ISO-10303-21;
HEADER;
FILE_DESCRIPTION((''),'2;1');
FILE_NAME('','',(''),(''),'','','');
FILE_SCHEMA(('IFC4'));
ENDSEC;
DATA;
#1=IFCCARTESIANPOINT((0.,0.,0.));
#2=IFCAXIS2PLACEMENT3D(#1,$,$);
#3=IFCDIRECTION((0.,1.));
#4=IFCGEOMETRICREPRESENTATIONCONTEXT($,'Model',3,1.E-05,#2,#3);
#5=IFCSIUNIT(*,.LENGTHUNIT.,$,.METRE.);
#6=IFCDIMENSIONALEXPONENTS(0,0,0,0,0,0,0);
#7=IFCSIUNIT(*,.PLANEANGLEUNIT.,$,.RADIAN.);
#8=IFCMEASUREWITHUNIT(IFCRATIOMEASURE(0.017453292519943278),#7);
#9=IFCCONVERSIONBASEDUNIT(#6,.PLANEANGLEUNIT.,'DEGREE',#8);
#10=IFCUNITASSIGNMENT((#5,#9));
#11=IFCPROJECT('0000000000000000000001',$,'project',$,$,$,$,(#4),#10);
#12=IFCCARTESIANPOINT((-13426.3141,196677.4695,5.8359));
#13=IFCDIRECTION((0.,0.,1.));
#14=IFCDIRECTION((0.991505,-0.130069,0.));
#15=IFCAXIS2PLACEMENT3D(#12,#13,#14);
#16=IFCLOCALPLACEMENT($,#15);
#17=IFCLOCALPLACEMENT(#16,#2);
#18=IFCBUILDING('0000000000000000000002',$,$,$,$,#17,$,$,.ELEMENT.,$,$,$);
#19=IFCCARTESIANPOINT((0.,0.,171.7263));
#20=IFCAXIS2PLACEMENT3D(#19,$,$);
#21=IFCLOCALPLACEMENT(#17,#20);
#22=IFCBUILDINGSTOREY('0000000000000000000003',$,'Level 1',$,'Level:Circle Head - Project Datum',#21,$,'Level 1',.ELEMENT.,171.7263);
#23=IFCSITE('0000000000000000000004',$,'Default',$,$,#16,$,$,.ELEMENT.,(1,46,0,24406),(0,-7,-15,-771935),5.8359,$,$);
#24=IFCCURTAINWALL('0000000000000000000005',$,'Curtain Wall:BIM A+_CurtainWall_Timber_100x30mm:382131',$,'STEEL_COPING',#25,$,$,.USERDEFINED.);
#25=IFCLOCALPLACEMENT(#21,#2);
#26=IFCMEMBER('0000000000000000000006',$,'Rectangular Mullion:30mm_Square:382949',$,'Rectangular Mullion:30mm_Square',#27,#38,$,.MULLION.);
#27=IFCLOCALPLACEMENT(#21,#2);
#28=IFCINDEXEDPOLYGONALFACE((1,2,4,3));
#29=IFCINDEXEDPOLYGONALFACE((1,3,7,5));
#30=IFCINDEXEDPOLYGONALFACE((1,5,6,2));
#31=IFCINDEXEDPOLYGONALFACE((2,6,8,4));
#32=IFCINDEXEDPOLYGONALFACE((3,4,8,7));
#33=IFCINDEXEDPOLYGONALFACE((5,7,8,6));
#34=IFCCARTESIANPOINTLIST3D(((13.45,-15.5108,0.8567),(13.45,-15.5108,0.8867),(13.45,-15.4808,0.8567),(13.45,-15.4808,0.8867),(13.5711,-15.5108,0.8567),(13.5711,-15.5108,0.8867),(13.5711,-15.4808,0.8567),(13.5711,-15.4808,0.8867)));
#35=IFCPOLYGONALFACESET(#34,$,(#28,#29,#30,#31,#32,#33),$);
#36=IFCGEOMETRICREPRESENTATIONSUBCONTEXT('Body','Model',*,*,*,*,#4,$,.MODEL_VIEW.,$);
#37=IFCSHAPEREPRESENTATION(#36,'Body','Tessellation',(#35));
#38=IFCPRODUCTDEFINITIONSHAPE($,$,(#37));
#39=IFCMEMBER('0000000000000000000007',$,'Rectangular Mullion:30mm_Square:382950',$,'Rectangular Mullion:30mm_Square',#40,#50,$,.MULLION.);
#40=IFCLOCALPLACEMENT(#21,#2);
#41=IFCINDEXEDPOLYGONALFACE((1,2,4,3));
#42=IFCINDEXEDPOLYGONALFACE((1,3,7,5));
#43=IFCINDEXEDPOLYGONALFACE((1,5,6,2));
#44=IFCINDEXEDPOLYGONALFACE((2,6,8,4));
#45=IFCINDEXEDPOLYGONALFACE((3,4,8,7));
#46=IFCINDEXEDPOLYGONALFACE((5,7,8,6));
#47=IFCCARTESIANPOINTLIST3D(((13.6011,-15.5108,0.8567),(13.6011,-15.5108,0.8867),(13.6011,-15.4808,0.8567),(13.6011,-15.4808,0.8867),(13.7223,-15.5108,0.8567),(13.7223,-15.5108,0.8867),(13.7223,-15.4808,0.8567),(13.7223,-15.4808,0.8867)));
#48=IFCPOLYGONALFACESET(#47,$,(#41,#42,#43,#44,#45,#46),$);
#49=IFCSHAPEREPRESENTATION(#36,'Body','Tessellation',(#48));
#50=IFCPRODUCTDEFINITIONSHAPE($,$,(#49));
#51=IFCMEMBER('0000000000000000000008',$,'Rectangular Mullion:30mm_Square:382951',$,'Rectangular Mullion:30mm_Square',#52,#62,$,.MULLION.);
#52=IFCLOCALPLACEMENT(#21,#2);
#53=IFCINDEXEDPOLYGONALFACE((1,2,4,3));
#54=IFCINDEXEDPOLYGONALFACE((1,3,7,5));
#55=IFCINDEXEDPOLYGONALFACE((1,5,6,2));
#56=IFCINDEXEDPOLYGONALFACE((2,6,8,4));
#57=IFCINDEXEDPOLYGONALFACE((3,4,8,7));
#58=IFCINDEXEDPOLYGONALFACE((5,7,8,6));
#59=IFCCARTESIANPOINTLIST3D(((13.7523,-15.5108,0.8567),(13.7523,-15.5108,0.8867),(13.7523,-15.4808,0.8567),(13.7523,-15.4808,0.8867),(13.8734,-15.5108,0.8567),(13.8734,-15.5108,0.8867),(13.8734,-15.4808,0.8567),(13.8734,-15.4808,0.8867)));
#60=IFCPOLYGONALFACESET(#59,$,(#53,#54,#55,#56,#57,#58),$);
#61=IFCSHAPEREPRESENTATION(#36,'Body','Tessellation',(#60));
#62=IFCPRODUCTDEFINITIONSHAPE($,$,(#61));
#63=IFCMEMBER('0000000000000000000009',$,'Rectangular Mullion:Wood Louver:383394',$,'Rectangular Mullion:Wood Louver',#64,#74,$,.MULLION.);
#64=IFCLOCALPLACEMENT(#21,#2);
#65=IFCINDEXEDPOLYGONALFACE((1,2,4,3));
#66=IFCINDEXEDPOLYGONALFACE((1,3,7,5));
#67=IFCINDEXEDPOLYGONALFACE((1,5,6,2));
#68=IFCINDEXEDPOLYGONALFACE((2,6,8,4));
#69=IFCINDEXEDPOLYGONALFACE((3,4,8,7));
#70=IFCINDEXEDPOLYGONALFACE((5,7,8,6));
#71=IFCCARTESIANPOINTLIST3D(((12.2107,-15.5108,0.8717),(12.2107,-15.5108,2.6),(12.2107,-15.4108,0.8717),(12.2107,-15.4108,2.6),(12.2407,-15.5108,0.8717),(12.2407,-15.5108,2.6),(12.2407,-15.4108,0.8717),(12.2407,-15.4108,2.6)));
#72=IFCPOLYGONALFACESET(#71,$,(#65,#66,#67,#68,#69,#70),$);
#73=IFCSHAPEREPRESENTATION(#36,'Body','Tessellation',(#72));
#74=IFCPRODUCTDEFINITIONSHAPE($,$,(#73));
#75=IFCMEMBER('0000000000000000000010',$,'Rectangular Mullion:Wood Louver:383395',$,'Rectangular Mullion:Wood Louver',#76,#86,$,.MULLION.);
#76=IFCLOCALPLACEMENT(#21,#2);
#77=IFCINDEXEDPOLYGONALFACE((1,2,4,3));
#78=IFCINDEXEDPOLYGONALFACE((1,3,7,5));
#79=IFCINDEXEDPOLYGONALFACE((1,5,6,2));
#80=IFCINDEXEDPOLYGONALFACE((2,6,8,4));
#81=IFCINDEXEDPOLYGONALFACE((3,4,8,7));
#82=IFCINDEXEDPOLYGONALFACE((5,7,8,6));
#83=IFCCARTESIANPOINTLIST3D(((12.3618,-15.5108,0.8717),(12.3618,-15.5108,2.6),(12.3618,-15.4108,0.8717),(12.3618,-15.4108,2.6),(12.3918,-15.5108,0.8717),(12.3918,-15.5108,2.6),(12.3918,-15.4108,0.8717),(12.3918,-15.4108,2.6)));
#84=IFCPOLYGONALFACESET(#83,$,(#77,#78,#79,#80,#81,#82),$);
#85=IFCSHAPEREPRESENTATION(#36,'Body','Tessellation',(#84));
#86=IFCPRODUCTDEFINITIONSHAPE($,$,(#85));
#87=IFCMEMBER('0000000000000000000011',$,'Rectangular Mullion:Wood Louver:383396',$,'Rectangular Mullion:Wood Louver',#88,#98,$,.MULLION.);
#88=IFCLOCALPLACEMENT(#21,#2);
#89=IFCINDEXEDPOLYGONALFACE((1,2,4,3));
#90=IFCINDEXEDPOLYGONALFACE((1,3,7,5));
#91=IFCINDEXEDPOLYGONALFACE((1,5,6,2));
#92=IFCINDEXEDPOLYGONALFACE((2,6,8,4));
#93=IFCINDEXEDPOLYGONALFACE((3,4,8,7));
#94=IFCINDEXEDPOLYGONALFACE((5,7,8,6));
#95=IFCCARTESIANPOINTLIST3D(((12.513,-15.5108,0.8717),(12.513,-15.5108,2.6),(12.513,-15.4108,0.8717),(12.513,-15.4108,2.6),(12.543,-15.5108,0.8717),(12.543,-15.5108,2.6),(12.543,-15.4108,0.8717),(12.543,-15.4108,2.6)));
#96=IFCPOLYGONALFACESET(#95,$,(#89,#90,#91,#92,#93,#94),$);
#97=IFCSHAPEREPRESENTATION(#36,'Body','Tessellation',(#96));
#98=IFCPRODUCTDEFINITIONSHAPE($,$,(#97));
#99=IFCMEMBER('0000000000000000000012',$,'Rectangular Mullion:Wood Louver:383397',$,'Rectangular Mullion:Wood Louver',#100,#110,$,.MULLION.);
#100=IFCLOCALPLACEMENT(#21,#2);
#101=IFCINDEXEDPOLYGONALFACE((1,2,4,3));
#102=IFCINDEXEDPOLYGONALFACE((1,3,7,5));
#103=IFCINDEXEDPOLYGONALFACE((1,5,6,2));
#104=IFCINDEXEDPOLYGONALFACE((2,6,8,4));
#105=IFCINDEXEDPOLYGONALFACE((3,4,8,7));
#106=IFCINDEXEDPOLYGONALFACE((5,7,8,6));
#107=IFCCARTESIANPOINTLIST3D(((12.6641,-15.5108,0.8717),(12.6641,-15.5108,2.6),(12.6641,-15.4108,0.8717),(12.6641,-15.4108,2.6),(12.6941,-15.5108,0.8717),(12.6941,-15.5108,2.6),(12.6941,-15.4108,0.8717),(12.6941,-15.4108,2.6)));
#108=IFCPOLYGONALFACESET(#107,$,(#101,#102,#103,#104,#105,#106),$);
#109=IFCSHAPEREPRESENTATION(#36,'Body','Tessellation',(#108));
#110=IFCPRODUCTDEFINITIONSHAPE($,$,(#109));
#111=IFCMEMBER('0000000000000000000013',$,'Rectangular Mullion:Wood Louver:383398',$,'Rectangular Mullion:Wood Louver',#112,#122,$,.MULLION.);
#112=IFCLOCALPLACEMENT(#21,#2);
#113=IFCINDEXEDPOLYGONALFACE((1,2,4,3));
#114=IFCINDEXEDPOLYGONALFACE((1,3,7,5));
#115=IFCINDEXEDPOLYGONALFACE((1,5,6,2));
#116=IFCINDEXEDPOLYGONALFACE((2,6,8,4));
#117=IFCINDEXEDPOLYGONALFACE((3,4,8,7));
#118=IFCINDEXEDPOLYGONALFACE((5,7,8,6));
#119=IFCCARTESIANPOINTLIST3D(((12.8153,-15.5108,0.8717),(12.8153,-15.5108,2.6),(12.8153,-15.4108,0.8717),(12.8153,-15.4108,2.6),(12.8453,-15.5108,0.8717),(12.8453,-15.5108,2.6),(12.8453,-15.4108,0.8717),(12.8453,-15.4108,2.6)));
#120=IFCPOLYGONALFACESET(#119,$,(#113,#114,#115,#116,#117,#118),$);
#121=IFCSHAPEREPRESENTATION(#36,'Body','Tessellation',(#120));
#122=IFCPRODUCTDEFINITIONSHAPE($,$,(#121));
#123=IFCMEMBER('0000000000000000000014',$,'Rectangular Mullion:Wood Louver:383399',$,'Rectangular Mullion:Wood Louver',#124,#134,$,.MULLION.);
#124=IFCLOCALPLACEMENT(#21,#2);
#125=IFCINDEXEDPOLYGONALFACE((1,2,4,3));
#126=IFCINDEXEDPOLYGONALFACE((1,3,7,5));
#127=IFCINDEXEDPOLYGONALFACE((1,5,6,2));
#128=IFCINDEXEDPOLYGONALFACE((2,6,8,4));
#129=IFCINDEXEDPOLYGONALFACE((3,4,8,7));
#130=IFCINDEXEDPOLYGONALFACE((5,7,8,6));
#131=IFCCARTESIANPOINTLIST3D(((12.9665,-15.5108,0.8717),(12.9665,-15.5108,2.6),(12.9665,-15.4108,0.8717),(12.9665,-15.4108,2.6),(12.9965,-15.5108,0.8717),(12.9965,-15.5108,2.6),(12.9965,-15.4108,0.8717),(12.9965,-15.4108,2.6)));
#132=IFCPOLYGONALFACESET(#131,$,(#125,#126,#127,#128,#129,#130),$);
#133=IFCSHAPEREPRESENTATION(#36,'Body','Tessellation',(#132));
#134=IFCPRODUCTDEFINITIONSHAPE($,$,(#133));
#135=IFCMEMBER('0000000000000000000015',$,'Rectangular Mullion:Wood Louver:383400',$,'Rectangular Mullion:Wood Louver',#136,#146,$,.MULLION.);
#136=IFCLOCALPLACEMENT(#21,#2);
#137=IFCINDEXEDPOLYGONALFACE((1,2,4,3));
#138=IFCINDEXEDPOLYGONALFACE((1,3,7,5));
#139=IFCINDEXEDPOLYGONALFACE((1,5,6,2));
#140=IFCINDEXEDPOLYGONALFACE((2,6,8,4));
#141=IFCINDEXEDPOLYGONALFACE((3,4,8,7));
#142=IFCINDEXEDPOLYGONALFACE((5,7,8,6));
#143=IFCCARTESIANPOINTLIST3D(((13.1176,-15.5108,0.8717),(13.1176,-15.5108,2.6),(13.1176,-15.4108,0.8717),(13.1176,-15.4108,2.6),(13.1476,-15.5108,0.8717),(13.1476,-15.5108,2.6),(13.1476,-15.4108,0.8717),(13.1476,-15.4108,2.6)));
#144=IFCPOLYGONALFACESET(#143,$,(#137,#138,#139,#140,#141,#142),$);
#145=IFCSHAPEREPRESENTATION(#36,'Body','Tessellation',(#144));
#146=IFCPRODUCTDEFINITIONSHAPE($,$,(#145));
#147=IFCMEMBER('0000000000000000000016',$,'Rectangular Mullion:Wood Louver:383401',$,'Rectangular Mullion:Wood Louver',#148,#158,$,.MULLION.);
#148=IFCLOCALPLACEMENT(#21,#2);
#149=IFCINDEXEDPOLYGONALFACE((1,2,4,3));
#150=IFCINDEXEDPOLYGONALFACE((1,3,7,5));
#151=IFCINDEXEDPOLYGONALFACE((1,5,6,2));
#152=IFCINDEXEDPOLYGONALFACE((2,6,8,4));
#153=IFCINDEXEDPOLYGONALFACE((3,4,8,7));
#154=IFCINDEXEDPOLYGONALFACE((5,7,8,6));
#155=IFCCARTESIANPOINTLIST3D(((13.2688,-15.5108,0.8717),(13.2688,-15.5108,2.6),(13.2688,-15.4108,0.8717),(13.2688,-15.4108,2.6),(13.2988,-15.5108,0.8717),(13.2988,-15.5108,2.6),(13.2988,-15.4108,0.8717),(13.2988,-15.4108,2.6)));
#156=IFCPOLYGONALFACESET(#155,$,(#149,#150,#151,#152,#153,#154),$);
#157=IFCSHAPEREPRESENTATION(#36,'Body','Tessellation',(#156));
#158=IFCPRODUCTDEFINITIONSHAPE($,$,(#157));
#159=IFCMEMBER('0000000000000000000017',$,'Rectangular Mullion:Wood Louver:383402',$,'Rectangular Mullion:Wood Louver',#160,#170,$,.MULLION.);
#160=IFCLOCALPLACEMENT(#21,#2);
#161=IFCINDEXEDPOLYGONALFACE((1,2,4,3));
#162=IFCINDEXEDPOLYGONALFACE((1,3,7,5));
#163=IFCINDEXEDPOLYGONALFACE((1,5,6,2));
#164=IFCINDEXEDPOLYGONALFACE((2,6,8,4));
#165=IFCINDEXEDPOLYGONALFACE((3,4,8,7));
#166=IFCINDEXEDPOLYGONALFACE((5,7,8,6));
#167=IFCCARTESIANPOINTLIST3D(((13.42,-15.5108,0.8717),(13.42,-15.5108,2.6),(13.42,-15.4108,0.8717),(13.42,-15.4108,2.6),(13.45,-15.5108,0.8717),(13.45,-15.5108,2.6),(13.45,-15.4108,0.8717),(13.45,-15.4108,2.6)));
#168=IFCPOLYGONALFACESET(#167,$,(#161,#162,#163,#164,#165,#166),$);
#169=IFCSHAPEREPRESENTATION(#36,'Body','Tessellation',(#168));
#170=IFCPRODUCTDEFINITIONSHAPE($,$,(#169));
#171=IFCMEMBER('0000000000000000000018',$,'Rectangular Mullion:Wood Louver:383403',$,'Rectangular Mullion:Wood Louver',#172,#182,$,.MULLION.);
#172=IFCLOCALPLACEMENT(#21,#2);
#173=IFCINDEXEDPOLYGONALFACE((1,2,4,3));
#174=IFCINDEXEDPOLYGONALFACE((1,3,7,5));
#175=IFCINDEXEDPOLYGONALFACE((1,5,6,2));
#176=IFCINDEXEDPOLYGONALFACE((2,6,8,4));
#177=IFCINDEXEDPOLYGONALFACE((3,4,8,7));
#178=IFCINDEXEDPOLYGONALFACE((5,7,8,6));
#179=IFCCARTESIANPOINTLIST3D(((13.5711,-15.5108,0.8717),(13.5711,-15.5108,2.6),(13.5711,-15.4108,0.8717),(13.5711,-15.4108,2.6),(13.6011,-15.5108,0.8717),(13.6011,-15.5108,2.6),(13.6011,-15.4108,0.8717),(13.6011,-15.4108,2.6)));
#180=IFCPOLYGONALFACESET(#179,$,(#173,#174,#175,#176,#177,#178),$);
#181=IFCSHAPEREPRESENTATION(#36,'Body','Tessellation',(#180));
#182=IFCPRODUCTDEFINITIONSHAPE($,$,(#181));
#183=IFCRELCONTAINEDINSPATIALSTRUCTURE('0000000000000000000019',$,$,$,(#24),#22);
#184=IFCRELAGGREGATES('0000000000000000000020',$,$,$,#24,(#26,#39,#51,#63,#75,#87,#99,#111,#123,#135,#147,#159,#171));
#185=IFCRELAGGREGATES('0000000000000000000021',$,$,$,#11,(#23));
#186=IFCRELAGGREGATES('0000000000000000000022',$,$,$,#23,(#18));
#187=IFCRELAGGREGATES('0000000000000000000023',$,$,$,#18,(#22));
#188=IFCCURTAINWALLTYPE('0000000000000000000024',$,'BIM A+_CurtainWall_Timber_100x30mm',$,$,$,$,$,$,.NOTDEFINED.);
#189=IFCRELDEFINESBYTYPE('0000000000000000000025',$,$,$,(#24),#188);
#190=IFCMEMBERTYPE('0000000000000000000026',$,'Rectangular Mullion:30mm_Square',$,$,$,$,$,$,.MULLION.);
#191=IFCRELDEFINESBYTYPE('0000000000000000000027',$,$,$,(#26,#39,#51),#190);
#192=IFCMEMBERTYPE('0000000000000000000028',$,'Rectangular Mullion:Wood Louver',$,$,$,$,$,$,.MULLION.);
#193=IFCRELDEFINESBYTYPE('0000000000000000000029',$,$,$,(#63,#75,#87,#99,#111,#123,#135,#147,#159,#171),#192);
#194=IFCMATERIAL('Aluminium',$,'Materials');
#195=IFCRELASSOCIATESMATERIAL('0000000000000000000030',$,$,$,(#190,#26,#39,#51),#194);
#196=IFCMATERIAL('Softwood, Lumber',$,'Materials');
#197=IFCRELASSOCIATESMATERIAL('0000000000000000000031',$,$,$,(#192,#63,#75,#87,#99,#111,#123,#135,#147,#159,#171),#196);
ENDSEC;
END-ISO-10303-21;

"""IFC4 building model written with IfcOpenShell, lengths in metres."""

from ifc_helpers import new_model, entity, si_unit, converted_unit, direction, frame, origin, place, context, subcontext, project, spatial, indexed_curve, outline, extrude, source, transform, mapped, material, type_object, type_shapes, element, aggregate, save


model = new_model("IFC4")

# Units and contexts
model_context = context("Model", 3, precision=1e-05, world=origin(), true_north=direction((0.0, 1.0)))
body_context = subcontext(model_context, "Body", "Model", "MODEL_VIEW")
ifc_project = project(units=[si_unit("LENGTHUNIT", "METRE"), converted_unit("PLANEANGLEUNIT", "DEGREE", entity("IfcRatioMeasure", 0.017453292519943278), si_unit("PLANEANGLEUNIT", "RADIAN"), dimensions=[0, 0, 0, 0, 0, 0, 0])], contexts=[model_context])

# Site, building, storey
site_placement = place(None, frame((-13426.3141, 196677.4695, 5.8359), z_axis=(0.0, 0.0, 1.0), x_axis=(0.991505, -0.130069, 0.0)))
site = spatial("IfcSite", under=ifc_project, at=site_placement, Name="Default", CompositionType="ELEMENT", RefLatitude=(1, 46, 0, 24406), RefLongitude=(0, -7, -15, -771935), RefElevation=5.8359)
building_placement = place(site_placement, origin())
building = spatial("IfcBuilding", under=site, at=building_placement, CompositionType="ELEMENT")
storey_placement = place(building_placement, frame((0.0, 0.0, 171.7263)))
storey = spatial("IfcBuildingStorey", under=building, at=storey_placement, Name="Level 1", ObjectType="Level:Circle Head - Project Datum", LongName="Level 1", CompositionType="ELEMENT", Elevation=171.7263)

# Shared definitions
ifc_material_1 = material(Name="Aluminium", Category="Materials")

# Curtain wall, members
curtain_wall_type_1 = type_object("IfcCurtainWallType", Name="BIM A+_CurtainWall_Timber_100x30mm", PredefinedType="NOTDEFINED")
curtain_wall_1_placement = place(storey_placement, frame((0.0, 0.0, -171.7263)))
curtain_wall_1 = element("IfcCurtainWall", 1, at=curtain_wall_1_placement, inside=storey, type_object=curtain_wall_type_1, Name="Curtain Wall:BIM A+_CurtainWall_Timber_100x30mm:382131", ObjectType="STEEL_COPING", PredefinedType="USERDEFINED")
member_type_1 = type_object("IfcMemberType", Name="Rectangular Mullion:30mm_Square", PredefinedType="MULLION", material=ifc_material_1)
shared_shape_1 = source(origin(), body_context, "Body", "SweptSolid", [
    extrude(outline(indexed_curve([(-0.015, -0.015), (0.015, -0.015), (0.015, 0.015), (-0.015, 0.015), (-0.015, -0.015)], self_intersect=False)), frame((0.0, 0.0, -0.1212), z_axis=(0.0, 0.0, 1.0), x_axis=(0.0, -1.0, 0.0)), (0.0, 0.0, 1.0), 0.1212),
])
type_shapes(member_type_1, [shared_shape_1])
member_1_placement = place(curtain_wall_1_placement, frame((13.5711, -15.4958, 172.598), z_axis=(1.0, 0.0, 0.0), x_axis=(0.0, 0.0, 1.0)))
member_1 = element("IfcMember", 2, at=member_1_placement, type_object=member_type_1, material=ifc_material_1, Name="Rectangular Mullion:30mm_Square:382949", ObjectType="Rectangular Mullion:30mm_Square", PredefinedType="MULLION", context=body_context, shape_type="MappedRepresentation", body=[
    mapped(shared_shape_1, transform((0.0, 0.0, 0.0), scale=1.0)),
])
member_2_placement = place(curtain_wall_1_placement, frame((13.7223, -15.4958, 172.598), z_axis=(1.0, 0.0, 0.0), x_axis=(0.0, 0.0, 1.0)))
member_2 = element("IfcMember", 3, at=member_2_placement, type_object=member_type_1, material=ifc_material_1, Name="Rectangular Mullion:30mm_Square:382950", ObjectType="Rectangular Mullion:30mm_Square", PredefinedType="MULLION", context=body_context, shape_type="MappedRepresentation", body=[
    mapped(shared_shape_1, transform((0.0, 0.0, 0.0), scale=1.0)),
])
member_3_placement = place(curtain_wall_1_placement, frame((13.8734, -15.4958, 172.598), z_axis=(1.0, 0.0, 0.0), x_axis=(0.0, 0.0, 1.0)))
member_3 = element("IfcMember", 4, at=member_3_placement, type_object=member_type_1, material=ifc_material_1, Name="Rectangular Mullion:30mm_Square:382951", ObjectType="Rectangular Mullion:30mm_Square", PredefinedType="MULLION", context=body_context, shape_type="MappedRepresentation", body=[
    mapped(shared_shape_1, transform((0.0, 0.0, 0.0), scale=1.0)),
])
ifc_material_2 = material(Name="Softwood, Lumber", Category="Materials")
member_type_2 = type_object("IfcMemberType", Name="Rectangular Mullion:Wood Louver", PredefinedType="MULLION", material=ifc_material_2)
shared_shape_2 = source(origin(), body_context, "Body", "SweptSolid", [
    extrude(outline(indexed_curve([(-0.05, -0.015), (0.05, -0.015), (0.05, 0.015), (-0.05, 0.015), (-0.05, -0.015)], self_intersect=False)), frame((0.0, -0.035, -1.7283), z_axis=(0.0, 0.0, 1.0), x_axis=(0.0, -1.0, 0.0)), (0.0, 0.0, 1.0), 1.7283),
])
type_shapes(member_type_2, [shared_shape_2])
member_4_placement = place(curtain_wall_1_placement, frame((12.2257, -15.4958, 172.598), z_axis=(0.0, 0.0, -1.0), x_axis=(1.0, 0.0, 0.0)))
member_4 = element("IfcMember", 5, at=member_4_placement, type_object=member_type_2, material=ifc_material_2, Name="Rectangular Mullion:Wood Louver:383394", ObjectType="Rectangular Mullion:Wood Louver", PredefinedType="MULLION", context=body_context, shape_type="MappedRepresentation", body=[
    mapped(shared_shape_2, transform((0.0, 0.0, 0.0), scale=1.0)),
])
member_5_placement = place(curtain_wall_1_placement, frame((12.3768, -15.4958, 172.598), z_axis=(0.0, 0.0, -1.0), x_axis=(1.0, 0.0, 0.0)))
member_5 = element("IfcMember", 6, at=member_5_placement, type_object=member_type_2, material=ifc_material_2, Name="Rectangular Mullion:Wood Louver:383395", ObjectType="Rectangular Mullion:Wood Louver", PredefinedType="MULLION", context=body_context, shape_type="MappedRepresentation", body=[
    mapped(shared_shape_2, transform((0.0, 0.0, 0.0), scale=1.0)),
])
member_6_placement = place(curtain_wall_1_placement, frame((12.528, -15.4958, 172.598), z_axis=(0.0, 0.0, -1.0), x_axis=(1.0, 0.0, 0.0)))
member_6 = element("IfcMember", 7, at=member_6_placement, type_object=member_type_2, material=ifc_material_2, Name="Rectangular Mullion:Wood Louver:383396", ObjectType="Rectangular Mullion:Wood Louver", PredefinedType="MULLION", context=body_context, shape_type="MappedRepresentation", body=[
    mapped(shared_shape_2, transform((0.0, 0.0, 0.0), scale=1.0)),
])
member_7_placement = place(curtain_wall_1_placement, frame((12.6791, -15.4958, 172.598), z_axis=(0.0, 0.0, -1.0), x_axis=(1.0, 0.0, 0.0)))
member_7 = element("IfcMember", 8, at=member_7_placement, type_object=member_type_2, material=ifc_material_2, Name="Rectangular Mullion:Wood Louver:383397", ObjectType="Rectangular Mullion:Wood Louver", PredefinedType="MULLION", context=body_context, shape_type="MappedRepresentation", body=[
    mapped(shared_shape_2, transform((0.0, 0.0, 0.0), scale=1.0)),
])
member_8_placement = place(curtain_wall_1_placement, frame((12.8303, -15.4958, 172.598), z_axis=(0.0, 0.0, -1.0), x_axis=(1.0, 0.0, 0.0)))
member_8 = element("IfcMember", 9, at=member_8_placement, type_object=member_type_2, material=ifc_material_2, Name="Rectangular Mullion:Wood Louver:383398", ObjectType="Rectangular Mullion:Wood Louver", PredefinedType="MULLION", context=body_context, shape_type="MappedRepresentation", body=[
    mapped(shared_shape_2, transform((0.0, 0.0, 0.0), scale=1.0)),
])
member_9_placement = place(curtain_wall_1_placement, frame((12.9815, -15.4958, 172.598), z_axis=(0.0, 0.0, -1.0), x_axis=(1.0, 0.0, 0.0)))
member_9 = element("IfcMember", 10, at=member_9_placement, type_object=member_type_2, material=ifc_material_2, Name="Rectangular Mullion:Wood Louver:383399", ObjectType="Rectangular Mullion:Wood Louver", PredefinedType="MULLION", context=body_context, shape_type="MappedRepresentation", body=[
    mapped(shared_shape_2, transform((0.0, 0.0, 0.0), scale=1.0)),
])
member_10_placement = place(curtain_wall_1_placement, frame((13.1326, -15.4958, 172.598), z_axis=(0.0, 0.0, -1.0), x_axis=(1.0, 0.0, 0.0)))
member_10 = element("IfcMember", 11, at=member_10_placement, type_object=member_type_2, material=ifc_material_2, Name="Rectangular Mullion:Wood Louver:383400", ObjectType="Rectangular Mullion:Wood Louver", PredefinedType="MULLION", context=body_context, shape_type="MappedRepresentation", body=[
    mapped(shared_shape_2, transform((0.0, 0.0, 0.0), scale=1.0)),
])
member_11_placement = place(curtain_wall_1_placement, frame((13.2838, -15.4958, 172.598), z_axis=(0.0, 0.0, -1.0), x_axis=(1.0, 0.0, 0.0)))
member_11 = element("IfcMember", 12, at=member_11_placement, type_object=member_type_2, material=ifc_material_2, Name="Rectangular Mullion:Wood Louver:383401", ObjectType="Rectangular Mullion:Wood Louver", PredefinedType="MULLION", context=body_context, shape_type="MappedRepresentation", body=[
    mapped(shared_shape_2, transform((0.0, 0.0, 0.0), scale=1.0)),
])
member_12_placement = place(curtain_wall_1_placement, frame((13.435, -15.4958, 172.598), z_axis=(0.0, 0.0, -1.0), x_axis=(1.0, 0.0, 0.0)))
member_12 = element("IfcMember", 13, at=member_12_placement, type_object=member_type_2, material=ifc_material_2, Name="Rectangular Mullion:Wood Louver:383402", ObjectType="Rectangular Mullion:Wood Louver", PredefinedType="MULLION", context=body_context, shape_type="MappedRepresentation", body=[
    mapped(shared_shape_2, transform((0.0, 0.0, 0.0), scale=1.0)),
])
member_13_placement = place(curtain_wall_1_placement, frame((13.5861, -15.4958, 172.598), z_axis=(0.0, 0.0, -1.0), x_axis=(1.0, 0.0, 0.0)))
member_13 = element("IfcMember", 14, at=member_13_placement, type_object=member_type_2, material=ifc_material_2, Name="Rectangular Mullion:Wood Louver:383403", ObjectType="Rectangular Mullion:Wood Louver", PredefinedType="MULLION", context=body_context, shape_type="MappedRepresentation", body=[
    mapped(shared_shape_2, transform((0.0, 0.0, 0.0), scale=1.0)),
])

aggregate(curtain_wall_1, [member_1, member_2, member_3, member_4, member_5, member_6, member_7, member_8, member_9, member_10, member_11, member_12, member_13])

save(model, "model.ifc")
